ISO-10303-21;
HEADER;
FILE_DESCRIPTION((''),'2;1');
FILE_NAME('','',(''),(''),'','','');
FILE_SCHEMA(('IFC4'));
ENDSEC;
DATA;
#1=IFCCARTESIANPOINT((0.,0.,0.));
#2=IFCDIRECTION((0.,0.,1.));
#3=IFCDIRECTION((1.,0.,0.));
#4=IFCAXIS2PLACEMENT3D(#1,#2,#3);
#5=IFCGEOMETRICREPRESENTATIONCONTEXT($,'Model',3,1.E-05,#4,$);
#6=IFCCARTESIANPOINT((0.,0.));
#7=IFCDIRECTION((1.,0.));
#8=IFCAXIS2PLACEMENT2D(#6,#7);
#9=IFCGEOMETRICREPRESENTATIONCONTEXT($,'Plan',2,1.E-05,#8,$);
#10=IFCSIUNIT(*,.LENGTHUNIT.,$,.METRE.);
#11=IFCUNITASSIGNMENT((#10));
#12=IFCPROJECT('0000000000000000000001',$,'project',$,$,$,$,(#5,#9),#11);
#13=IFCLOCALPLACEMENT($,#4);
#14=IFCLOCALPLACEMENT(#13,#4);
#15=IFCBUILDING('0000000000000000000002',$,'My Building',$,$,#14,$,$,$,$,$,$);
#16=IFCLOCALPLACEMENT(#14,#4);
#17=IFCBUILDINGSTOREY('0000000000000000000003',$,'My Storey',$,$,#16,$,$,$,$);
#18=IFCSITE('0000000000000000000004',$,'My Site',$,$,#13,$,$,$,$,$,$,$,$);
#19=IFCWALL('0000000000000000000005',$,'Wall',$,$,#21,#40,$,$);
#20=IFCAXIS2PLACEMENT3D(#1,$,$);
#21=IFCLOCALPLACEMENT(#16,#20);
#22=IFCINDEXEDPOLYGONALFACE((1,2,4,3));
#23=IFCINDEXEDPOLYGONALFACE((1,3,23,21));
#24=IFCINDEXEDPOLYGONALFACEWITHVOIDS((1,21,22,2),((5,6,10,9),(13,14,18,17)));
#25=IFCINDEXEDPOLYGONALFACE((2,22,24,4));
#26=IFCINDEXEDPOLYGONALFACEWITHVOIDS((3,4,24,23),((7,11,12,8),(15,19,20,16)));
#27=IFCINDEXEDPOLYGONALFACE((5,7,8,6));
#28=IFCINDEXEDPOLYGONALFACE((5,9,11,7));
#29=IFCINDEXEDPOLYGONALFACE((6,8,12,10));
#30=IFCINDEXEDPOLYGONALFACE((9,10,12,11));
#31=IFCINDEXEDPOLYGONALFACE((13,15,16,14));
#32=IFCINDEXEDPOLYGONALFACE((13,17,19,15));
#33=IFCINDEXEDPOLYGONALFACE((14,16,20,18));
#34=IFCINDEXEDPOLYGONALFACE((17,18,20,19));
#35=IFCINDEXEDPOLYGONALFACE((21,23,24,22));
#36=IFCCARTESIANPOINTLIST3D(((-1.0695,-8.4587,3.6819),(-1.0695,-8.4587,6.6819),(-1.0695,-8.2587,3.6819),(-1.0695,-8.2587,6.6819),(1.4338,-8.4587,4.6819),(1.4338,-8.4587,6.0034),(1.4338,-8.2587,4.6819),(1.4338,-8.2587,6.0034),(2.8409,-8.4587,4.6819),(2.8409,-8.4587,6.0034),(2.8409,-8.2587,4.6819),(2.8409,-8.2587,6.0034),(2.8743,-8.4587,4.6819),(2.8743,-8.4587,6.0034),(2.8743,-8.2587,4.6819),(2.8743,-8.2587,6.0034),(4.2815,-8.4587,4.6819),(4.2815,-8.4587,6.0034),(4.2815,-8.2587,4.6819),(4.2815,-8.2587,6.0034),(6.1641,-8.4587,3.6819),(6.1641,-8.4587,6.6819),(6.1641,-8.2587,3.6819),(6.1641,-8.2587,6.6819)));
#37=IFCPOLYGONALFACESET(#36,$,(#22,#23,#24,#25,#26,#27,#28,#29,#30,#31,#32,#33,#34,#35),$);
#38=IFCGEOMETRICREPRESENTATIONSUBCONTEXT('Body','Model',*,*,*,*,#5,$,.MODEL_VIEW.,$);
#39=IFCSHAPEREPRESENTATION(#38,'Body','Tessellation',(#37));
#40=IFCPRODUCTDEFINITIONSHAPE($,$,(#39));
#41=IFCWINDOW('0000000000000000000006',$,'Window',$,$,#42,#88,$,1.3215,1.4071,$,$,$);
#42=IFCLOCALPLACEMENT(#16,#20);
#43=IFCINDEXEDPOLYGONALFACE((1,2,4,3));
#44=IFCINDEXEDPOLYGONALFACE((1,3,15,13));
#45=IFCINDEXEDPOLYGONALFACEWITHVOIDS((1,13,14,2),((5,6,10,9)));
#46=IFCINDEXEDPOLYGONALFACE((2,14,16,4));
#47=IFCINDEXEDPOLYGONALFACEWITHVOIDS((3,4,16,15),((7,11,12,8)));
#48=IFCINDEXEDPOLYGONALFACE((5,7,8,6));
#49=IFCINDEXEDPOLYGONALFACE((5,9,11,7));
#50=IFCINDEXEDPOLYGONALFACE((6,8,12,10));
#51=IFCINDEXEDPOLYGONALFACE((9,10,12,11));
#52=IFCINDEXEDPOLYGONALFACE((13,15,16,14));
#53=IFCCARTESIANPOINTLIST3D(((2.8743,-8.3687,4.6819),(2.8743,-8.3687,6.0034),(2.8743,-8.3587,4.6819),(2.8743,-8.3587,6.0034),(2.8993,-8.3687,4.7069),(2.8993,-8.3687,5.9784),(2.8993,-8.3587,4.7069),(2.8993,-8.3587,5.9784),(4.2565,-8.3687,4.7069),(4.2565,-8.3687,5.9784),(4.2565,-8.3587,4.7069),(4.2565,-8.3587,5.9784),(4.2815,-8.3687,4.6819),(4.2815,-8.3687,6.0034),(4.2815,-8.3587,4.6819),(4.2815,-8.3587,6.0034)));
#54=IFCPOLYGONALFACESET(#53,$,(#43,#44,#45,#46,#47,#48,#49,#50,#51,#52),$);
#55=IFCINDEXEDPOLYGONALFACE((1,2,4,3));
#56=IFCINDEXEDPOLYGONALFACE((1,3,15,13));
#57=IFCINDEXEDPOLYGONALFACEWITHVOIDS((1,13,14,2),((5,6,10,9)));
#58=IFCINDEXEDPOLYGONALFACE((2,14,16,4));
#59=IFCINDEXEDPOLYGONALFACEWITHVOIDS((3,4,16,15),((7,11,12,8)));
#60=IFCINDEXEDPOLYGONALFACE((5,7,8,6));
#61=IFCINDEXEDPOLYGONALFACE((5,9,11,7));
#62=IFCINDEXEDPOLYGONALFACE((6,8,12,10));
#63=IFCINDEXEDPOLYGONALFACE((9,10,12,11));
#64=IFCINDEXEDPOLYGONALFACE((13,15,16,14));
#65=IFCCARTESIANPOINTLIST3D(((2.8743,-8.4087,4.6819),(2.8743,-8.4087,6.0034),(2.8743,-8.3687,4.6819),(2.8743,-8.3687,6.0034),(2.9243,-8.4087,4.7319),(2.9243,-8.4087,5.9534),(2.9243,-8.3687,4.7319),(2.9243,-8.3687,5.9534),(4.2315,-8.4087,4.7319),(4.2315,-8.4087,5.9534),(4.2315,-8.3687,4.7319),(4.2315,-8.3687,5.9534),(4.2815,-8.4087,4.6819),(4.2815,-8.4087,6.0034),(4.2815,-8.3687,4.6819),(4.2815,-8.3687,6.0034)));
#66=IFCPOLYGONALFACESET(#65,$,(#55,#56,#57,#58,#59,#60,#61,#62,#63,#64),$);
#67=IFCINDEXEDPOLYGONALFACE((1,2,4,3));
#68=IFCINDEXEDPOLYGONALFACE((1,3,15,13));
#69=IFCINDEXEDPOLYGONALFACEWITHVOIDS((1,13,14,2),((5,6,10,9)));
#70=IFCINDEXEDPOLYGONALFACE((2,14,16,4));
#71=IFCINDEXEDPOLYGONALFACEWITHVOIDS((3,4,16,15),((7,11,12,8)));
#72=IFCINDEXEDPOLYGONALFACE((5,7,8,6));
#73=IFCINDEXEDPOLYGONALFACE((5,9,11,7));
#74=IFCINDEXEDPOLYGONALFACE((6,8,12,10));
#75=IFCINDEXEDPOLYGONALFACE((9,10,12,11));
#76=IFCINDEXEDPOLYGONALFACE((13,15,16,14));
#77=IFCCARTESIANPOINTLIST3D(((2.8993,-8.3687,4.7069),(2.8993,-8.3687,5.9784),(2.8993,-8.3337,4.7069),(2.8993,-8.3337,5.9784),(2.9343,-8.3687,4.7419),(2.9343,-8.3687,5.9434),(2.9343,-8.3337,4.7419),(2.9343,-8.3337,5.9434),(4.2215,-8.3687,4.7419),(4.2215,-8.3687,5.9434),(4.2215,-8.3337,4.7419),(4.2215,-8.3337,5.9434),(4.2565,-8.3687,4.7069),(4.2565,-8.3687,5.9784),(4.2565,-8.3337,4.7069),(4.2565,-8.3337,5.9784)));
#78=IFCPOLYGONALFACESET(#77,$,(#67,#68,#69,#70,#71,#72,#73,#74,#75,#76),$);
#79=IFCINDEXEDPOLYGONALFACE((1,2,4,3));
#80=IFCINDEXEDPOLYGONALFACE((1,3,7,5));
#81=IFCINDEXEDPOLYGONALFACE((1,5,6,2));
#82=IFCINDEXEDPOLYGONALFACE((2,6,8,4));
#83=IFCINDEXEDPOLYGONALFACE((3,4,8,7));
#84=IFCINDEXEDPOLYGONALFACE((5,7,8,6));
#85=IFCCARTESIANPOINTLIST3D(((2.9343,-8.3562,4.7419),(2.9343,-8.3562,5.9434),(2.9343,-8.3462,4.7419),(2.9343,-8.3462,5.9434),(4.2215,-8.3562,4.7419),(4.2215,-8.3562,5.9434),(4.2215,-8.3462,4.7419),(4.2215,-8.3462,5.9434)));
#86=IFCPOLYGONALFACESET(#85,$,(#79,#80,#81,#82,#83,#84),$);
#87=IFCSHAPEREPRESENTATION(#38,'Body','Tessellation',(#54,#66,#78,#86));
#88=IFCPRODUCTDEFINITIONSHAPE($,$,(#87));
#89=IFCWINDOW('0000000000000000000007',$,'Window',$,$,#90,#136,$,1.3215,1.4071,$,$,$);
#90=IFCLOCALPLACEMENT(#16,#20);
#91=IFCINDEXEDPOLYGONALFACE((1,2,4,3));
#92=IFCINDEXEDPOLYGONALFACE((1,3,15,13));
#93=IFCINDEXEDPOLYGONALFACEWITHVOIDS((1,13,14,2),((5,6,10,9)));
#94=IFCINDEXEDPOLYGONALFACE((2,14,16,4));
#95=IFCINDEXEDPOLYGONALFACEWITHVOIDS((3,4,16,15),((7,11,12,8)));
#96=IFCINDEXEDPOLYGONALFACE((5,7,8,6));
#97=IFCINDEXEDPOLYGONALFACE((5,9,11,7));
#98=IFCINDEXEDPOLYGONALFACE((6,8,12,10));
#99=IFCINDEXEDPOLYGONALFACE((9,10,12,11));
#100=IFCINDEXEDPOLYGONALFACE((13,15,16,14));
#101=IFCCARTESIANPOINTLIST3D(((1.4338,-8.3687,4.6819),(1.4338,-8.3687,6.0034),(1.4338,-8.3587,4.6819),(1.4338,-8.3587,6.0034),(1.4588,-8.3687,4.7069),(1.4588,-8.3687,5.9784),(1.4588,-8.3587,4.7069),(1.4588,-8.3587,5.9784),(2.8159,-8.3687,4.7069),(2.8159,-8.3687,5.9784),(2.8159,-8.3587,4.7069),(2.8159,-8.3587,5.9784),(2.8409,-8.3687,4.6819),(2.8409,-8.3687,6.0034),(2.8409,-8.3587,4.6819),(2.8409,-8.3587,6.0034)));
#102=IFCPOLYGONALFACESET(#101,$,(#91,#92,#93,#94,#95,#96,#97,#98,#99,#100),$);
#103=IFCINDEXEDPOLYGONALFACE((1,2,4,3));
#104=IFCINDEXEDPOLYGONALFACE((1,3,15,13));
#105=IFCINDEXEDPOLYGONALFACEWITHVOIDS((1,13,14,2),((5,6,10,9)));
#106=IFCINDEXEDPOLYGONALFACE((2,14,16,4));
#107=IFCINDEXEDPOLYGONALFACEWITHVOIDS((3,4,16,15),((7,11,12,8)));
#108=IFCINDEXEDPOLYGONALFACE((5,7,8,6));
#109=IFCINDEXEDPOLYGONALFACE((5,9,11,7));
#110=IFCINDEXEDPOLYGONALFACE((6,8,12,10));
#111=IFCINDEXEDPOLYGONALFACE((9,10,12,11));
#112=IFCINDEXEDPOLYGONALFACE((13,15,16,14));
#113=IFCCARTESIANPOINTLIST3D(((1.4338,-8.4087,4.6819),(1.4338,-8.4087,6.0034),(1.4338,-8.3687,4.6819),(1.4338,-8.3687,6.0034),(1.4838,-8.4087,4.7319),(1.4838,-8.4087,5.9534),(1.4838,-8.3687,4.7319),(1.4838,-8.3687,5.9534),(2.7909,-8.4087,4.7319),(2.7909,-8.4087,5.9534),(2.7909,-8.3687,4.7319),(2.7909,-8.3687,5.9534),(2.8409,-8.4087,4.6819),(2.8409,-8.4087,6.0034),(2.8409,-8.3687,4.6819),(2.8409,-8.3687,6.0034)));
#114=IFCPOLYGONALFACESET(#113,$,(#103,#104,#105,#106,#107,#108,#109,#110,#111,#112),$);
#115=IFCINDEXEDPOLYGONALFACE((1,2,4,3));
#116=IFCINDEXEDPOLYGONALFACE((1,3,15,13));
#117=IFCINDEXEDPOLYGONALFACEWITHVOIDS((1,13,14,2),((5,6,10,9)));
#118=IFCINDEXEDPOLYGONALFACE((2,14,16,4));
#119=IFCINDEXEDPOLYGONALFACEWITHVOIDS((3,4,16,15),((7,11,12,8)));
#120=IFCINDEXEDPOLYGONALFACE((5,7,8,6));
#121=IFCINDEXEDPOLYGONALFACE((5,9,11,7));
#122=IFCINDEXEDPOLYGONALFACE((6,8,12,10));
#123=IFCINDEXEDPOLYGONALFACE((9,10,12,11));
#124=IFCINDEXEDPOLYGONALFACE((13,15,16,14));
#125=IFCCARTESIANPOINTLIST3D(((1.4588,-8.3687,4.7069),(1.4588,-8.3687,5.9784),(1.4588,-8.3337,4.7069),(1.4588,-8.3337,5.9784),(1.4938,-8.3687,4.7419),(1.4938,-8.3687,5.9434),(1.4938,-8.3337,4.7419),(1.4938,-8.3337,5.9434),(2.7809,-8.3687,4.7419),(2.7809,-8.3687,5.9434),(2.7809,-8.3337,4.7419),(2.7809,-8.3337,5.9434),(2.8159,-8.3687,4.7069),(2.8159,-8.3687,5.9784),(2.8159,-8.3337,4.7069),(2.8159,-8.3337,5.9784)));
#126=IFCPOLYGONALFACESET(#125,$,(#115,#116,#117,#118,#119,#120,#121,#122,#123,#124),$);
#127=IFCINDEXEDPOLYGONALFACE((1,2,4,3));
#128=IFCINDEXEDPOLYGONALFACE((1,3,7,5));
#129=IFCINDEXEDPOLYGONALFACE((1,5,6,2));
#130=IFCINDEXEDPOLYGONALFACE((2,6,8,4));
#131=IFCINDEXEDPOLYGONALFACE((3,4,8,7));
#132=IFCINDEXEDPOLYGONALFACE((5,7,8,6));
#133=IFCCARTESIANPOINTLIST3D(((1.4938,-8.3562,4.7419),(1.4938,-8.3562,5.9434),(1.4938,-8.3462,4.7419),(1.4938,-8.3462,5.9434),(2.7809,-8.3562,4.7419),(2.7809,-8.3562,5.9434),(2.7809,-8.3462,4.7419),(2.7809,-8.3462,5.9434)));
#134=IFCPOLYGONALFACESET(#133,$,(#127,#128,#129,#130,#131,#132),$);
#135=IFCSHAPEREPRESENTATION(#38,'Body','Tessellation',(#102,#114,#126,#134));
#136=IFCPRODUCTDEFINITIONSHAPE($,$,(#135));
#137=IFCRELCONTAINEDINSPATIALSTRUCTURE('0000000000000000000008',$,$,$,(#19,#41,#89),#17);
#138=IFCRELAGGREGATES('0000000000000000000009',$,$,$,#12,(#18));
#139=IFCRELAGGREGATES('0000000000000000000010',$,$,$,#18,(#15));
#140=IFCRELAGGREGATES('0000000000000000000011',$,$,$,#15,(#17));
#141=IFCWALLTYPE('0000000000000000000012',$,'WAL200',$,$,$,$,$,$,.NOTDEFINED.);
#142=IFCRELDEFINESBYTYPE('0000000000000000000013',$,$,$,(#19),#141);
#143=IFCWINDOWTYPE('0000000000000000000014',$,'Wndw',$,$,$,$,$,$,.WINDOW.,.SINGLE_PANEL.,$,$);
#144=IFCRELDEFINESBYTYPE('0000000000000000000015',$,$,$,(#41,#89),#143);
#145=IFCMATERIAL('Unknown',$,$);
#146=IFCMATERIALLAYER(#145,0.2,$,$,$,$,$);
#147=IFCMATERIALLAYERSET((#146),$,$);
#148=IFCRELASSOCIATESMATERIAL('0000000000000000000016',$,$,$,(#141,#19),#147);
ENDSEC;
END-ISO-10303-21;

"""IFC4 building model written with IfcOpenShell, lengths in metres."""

from ifc_helpers import new_model, entity, si_unit, frame, origin_with_axes, origin_2d_with_axis, place, context, subcontext, project, spatial, line, indexed_curve, outline, extrude, shape, source, transform, mapped, material, layer, layer_set, layer_usage, type_object, type_shapes, element, fill, save


model = new_model("IFC4")

# Units and contexts
model_context = context("Model", 3, precision=1e-05, world=origin_with_axes())
plan_context = context("Plan", 2, precision=1e-05, world=origin_2d_with_axis())
body_context_1 = subcontext(model_context, "Body", "Model", "MODEL_VIEW")
body_context_2 = subcontext(plan_context, "Body", "Plan", "PLAN_VIEW")
ifc_project = project(units=[si_unit("LENGTHUNIT", "METRE")], contexts=[model_context, plan_context])

# Site, building, storey
site_placement = place(None, origin_with_axes())
site = spatial("IfcSite", under=ifc_project, at=site_placement, Name="My Site")
building_placement = place(site_placement, origin_with_axes())
building = spatial("IfcBuilding", under=site, at=building_placement, Name="My Building")
storey_placement = place(building_placement, origin_with_axes())
storey = spatial("IfcBuildingStorey", under=building, at=storey_placement, Name="My Storey")

# Shared definitions
ifc_material = material(Name="Unknown")
ifc_layer = layer(ifc_material, 0.2)
ifc_layer_set = layer_set([ifc_layer])
wall_type = type_object("IfcWallType", Name="WAL200", PredefinedType="NOTDEFINED", material=ifc_layer_set)
shared_shape_1 = source(origin_with_axes(), body_context_1, "Body", "SweptSolid", [
    extrude(outline(indexed_curve([(0.0, 0.0), (1.4071, 0.0), (1.4071, 1.3215), (0.0, 1.3215)], segments=[line(1, 2, 3, 4, 1)])), frame((0.0, -0.6, 0.0), z_axis=(0.0, -1.0, 0.0), x_axis=(1.0, 0.0, 0.0)), (0.0, 0.0, -1.0), 1.2),
])
window_type = type_object("IfcWindowType", Name="Wndw", PartitioningType="SINGLE_PANEL", PredefinedType="WINDOW")
shared_shape_2 = source(origin_with_axes(), body_context_1, "Body", "SweptSolid", [
    extrude(outline(indexed_curve([(0.0, 0.0), (1.4071, 0.0), (1.4071, 1.3215), (0.0, 1.3215)], segments=[line(1, 2, 3, 4, 1)]), holes=[indexed_curve([(0.025, 0.025), (1.3821, 0.025), (1.3821, 1.2965), (0.025, 1.2965)], segments=[line(1, 2, 3, 4, 1)])]), frame((0.0, 0.09, 0.0), z_axis=(0.0, -1.0, 0.0), x_axis=(1.0, 0.0, 0.0)), (0.0, 0.0, -1.0), 0.01),
    extrude(outline(indexed_curve([(0.0, 0.0), (1.4071, 0.0), (1.4071, 1.3215), (0.0, 1.3215)], segments=[line(1, 2, 3, 4, 1)]), holes=[indexed_curve([(0.05, 0.05), (1.3571, 0.05), (1.3571, 1.2715), (0.05, 1.2715)], segments=[line(1, 2, 3, 4, 1)])]), frame((0.0, 0.05, 0.0), z_axis=(0.0, -1.0, 0.0), x_axis=(1.0, 0.0, 0.0)), (0.0, 0.0, -1.0), 0.04),
    extrude(outline(indexed_curve([(0.0, 0.0), (1.3571, 0.0), (1.3571, 1.2715), (0.0, 1.2715)], segments=[line(1, 2, 3, 4, 1)]), holes=[indexed_curve([(0.035, 0.035), (1.3221, 0.035), (1.3221, 1.2365), (0.035, 1.2365)], segments=[line(1, 2, 3, 4, 1)])]), frame((0.025, 0.09, 0.025), z_axis=(0.0, -1.0, 0.0), x_axis=(1.0, 0.0, 0.0)), (0.0, 0.0, -1.0), 0.035),
    extrude(outline(indexed_curve([(0.035, 0.035), (1.3221, 0.035), (1.3221, 1.2365), (0.035, 1.2365)], segments=[line(1, 2, 3, 4, 1)])), frame((0.025, 0.1025, 0.025), z_axis=(0.0, -1.0, 0.0), x_axis=(1.0, 0.0, 0.0)), (0.0, 0.0, -1.0), 0.01),
])
shared_shape_3 = source(origin_with_axes(), body_context_2, "Body", "Curve2D", [
    entity("IfcIndexedPolyCurve", entity("IfcCartesianPointList2D", [[0.05, 0.05], [1.3571, 0.05]])),
    entity("IfcIndexedPolyCurve", entity("IfcCartesianPointList2D", [[0.0, 0.1], [0.025, 0.1], [0.025, 0.09], [0.05, 0.09], [0.05, 0.05], [0.0, 0.05]]), [entity("IfcLineIndex", [1, 2, 3, 4, 5, 6, 1])]),
    entity("IfcIndexedPolyCurve", entity("IfcCartesianPointList2D", [[1.4071, 0.1], [1.3821, 0.1], [1.3821, 0.09], [1.3571, 0.09], [1.3571, 0.05], [1.4071, 0.05]]), [entity("IfcLineIndex", [1, 2, 3, 4, 5, 6, 1])]),
    entity("IfcIndexedPolyCurve", entity("IfcCartesianPointList2D", [[0.025, 0.09], [0.06, 0.09], [0.06, 0.125], [0.025, 0.125]]), [entity("IfcLineIndex", [1, 2, 3, 4, 1])]),
    entity("IfcIndexedPolyCurve", entity("IfcCartesianPointList2D", [[1.3821, 0.09], [1.3471, 0.09], [1.3471, 0.125], [1.3821, 0.125]]), [entity("IfcLineIndex", [1, 2, 3, 4, 1])]),
    entity("IfcIndexedPolyCurve", entity("IfcCartesianPointList2D", [[0.06, 0.09], [1.3471, 0.09]])),
    entity("IfcIndexedPolyCurve", entity("IfcCartesianPointList2D", [[0.06, 0.125], [1.3471, 0.125]])),
    entity("IfcIndexedPolyCurve", entity("IfcCartesianPointList2D", [[0.06, 0.1075], [1.3471, 0.1075]])),
])
type_shapes(window_type, [shared_shape_2, shared_shape_3])

# Wall, openings, windows
ifc_layer_usage_1 = layer_usage(ifc_layer_set, "AXIS2", "POSITIVE", 0.0)
wall_1_placement = place(storey_placement, frame((6.1641, -8.2587, 3.6819), z_axis=(0.0, 0.0, 1.0), x_axis=(-1.0, 0.0, 0.0)))
wall_1 = element("IfcWall", 1, at=wall_1_placement, inside=storey, type_object=wall_type, material=ifc_layer_usage_1, Name="Wall", context=body_context_1, shape_type="SweptSolid", body=[
    extrude(outline(indexed_curve([(0.0, 0.0), (0.0, 0.2), (7.2336, 0.2), (7.2336, 0.0)], segments=[line(1, 2, 3, 4, 1)])), origin_with_axes(), (0.0, 0.0, 1.0), 3.0),
])
opening_1_placement = place(wall_1_placement, frame((3.2898, 0.2, 1.0), z_axis=(0.0, 0.0, 1.0), x_axis=(-1.0, 0.0, 0.0)))
opening_1 = element("IfcOpeningElement", 2, at=opening_1_placement, cuts=wall_1, PredefinedType="OPENING", context=body_context_1, shape_type="MappedRepresentation", body=[
    mapped(shared_shape_1, transform((0.0, 0.0, 0.0), x_axis=(1.0, 0.0, 0.0), y_axis=(0.0, 1.0, 0.0), z_axis=(0.0, 0.0, 1.0), scale=1.0)),
])
opening_2_placement = place(wall_1_placement, frame((4.7303, 0.2, 1.0), z_axis=(0.0, 0.0, 1.0), x_axis=(-1.0, 0.0, 0.0)))
opening_2 = element("IfcOpeningElement", 3, at=opening_2_placement, cuts=wall_1, PredefinedType="OPENING", context=body_context_1, shape_type="MappedRepresentation", body=[
    mapped(shared_shape_1, transform((0.0, 0.0, 0.0), x_axis=(1.0, 0.0, 0.0), y_axis=(0.0, 1.0, 0.0), z_axis=(0.0, 0.0, 1.0), scale=1.0)),
])
window_1_placement = place(opening_1_placement, frame((0.0, 0.0, 0.0), z_axis=(0.0, 0.0, 1.0), x_axis=(1.0, 0.0, 0.0)))
window_1 = element("IfcWindow", 4, at=window_1_placement, inside=storey, type_object=window_type, Name="Window", OverallHeight=1.3215, OverallWidth=1.4071, shapes=[
    shape(body_context_1, "Body", "MappedRepresentation", [mapped(shared_shape_2, transform((0.0, 0.0, 0.0), x_axis=(1.0, 0.0, 0.0), y_axis=(0.0, 1.0, 0.0), z_axis=(0.0, 0.0, 1.0), scale=1.0))]),
    shape(body_context_2, "Body", "MappedRepresentation", [mapped(shared_shape_3, transform((0.0, 0.0, 0.0), x_axis=(1.0, 0.0, 0.0), y_axis=(0.0, 1.0, 0.0), z_axis=(0.0, 0.0, 1.0), scale=1.0))]),
])
fill(opening_1, window_1)
window_2_placement = place(opening_2_placement, frame((0.0, 0.0, 0.0), z_axis=(0.0, 0.0, 1.0), x_axis=(1.0, 0.0, 0.0)))
window_2 = element("IfcWindow", 5, at=window_2_placement, inside=storey, type_object=window_type, Name="Window", OverallHeight=1.3215, OverallWidth=1.4071, shapes=[
    shape(body_context_1, "Body", "MappedRepresentation", [mapped(shared_shape_2, transform((0.0, 0.0, 0.0), x_axis=(1.0, 0.0, 0.0), y_axis=(0.0, 1.0, 0.0), z_axis=(0.0, 0.0, 1.0), scale=1.0))]),
    shape(body_context_2, "Body", "MappedRepresentation", [mapped(shared_shape_3, transform((0.0, 0.0, 0.0), x_axis=(1.0, 0.0, 0.0), y_axis=(0.0, 1.0, 0.0), z_axis=(0.0, 0.0, 1.0), scale=1.0))]),
])
fill(opening_2, window_2)

save(model, "model.ifc")
